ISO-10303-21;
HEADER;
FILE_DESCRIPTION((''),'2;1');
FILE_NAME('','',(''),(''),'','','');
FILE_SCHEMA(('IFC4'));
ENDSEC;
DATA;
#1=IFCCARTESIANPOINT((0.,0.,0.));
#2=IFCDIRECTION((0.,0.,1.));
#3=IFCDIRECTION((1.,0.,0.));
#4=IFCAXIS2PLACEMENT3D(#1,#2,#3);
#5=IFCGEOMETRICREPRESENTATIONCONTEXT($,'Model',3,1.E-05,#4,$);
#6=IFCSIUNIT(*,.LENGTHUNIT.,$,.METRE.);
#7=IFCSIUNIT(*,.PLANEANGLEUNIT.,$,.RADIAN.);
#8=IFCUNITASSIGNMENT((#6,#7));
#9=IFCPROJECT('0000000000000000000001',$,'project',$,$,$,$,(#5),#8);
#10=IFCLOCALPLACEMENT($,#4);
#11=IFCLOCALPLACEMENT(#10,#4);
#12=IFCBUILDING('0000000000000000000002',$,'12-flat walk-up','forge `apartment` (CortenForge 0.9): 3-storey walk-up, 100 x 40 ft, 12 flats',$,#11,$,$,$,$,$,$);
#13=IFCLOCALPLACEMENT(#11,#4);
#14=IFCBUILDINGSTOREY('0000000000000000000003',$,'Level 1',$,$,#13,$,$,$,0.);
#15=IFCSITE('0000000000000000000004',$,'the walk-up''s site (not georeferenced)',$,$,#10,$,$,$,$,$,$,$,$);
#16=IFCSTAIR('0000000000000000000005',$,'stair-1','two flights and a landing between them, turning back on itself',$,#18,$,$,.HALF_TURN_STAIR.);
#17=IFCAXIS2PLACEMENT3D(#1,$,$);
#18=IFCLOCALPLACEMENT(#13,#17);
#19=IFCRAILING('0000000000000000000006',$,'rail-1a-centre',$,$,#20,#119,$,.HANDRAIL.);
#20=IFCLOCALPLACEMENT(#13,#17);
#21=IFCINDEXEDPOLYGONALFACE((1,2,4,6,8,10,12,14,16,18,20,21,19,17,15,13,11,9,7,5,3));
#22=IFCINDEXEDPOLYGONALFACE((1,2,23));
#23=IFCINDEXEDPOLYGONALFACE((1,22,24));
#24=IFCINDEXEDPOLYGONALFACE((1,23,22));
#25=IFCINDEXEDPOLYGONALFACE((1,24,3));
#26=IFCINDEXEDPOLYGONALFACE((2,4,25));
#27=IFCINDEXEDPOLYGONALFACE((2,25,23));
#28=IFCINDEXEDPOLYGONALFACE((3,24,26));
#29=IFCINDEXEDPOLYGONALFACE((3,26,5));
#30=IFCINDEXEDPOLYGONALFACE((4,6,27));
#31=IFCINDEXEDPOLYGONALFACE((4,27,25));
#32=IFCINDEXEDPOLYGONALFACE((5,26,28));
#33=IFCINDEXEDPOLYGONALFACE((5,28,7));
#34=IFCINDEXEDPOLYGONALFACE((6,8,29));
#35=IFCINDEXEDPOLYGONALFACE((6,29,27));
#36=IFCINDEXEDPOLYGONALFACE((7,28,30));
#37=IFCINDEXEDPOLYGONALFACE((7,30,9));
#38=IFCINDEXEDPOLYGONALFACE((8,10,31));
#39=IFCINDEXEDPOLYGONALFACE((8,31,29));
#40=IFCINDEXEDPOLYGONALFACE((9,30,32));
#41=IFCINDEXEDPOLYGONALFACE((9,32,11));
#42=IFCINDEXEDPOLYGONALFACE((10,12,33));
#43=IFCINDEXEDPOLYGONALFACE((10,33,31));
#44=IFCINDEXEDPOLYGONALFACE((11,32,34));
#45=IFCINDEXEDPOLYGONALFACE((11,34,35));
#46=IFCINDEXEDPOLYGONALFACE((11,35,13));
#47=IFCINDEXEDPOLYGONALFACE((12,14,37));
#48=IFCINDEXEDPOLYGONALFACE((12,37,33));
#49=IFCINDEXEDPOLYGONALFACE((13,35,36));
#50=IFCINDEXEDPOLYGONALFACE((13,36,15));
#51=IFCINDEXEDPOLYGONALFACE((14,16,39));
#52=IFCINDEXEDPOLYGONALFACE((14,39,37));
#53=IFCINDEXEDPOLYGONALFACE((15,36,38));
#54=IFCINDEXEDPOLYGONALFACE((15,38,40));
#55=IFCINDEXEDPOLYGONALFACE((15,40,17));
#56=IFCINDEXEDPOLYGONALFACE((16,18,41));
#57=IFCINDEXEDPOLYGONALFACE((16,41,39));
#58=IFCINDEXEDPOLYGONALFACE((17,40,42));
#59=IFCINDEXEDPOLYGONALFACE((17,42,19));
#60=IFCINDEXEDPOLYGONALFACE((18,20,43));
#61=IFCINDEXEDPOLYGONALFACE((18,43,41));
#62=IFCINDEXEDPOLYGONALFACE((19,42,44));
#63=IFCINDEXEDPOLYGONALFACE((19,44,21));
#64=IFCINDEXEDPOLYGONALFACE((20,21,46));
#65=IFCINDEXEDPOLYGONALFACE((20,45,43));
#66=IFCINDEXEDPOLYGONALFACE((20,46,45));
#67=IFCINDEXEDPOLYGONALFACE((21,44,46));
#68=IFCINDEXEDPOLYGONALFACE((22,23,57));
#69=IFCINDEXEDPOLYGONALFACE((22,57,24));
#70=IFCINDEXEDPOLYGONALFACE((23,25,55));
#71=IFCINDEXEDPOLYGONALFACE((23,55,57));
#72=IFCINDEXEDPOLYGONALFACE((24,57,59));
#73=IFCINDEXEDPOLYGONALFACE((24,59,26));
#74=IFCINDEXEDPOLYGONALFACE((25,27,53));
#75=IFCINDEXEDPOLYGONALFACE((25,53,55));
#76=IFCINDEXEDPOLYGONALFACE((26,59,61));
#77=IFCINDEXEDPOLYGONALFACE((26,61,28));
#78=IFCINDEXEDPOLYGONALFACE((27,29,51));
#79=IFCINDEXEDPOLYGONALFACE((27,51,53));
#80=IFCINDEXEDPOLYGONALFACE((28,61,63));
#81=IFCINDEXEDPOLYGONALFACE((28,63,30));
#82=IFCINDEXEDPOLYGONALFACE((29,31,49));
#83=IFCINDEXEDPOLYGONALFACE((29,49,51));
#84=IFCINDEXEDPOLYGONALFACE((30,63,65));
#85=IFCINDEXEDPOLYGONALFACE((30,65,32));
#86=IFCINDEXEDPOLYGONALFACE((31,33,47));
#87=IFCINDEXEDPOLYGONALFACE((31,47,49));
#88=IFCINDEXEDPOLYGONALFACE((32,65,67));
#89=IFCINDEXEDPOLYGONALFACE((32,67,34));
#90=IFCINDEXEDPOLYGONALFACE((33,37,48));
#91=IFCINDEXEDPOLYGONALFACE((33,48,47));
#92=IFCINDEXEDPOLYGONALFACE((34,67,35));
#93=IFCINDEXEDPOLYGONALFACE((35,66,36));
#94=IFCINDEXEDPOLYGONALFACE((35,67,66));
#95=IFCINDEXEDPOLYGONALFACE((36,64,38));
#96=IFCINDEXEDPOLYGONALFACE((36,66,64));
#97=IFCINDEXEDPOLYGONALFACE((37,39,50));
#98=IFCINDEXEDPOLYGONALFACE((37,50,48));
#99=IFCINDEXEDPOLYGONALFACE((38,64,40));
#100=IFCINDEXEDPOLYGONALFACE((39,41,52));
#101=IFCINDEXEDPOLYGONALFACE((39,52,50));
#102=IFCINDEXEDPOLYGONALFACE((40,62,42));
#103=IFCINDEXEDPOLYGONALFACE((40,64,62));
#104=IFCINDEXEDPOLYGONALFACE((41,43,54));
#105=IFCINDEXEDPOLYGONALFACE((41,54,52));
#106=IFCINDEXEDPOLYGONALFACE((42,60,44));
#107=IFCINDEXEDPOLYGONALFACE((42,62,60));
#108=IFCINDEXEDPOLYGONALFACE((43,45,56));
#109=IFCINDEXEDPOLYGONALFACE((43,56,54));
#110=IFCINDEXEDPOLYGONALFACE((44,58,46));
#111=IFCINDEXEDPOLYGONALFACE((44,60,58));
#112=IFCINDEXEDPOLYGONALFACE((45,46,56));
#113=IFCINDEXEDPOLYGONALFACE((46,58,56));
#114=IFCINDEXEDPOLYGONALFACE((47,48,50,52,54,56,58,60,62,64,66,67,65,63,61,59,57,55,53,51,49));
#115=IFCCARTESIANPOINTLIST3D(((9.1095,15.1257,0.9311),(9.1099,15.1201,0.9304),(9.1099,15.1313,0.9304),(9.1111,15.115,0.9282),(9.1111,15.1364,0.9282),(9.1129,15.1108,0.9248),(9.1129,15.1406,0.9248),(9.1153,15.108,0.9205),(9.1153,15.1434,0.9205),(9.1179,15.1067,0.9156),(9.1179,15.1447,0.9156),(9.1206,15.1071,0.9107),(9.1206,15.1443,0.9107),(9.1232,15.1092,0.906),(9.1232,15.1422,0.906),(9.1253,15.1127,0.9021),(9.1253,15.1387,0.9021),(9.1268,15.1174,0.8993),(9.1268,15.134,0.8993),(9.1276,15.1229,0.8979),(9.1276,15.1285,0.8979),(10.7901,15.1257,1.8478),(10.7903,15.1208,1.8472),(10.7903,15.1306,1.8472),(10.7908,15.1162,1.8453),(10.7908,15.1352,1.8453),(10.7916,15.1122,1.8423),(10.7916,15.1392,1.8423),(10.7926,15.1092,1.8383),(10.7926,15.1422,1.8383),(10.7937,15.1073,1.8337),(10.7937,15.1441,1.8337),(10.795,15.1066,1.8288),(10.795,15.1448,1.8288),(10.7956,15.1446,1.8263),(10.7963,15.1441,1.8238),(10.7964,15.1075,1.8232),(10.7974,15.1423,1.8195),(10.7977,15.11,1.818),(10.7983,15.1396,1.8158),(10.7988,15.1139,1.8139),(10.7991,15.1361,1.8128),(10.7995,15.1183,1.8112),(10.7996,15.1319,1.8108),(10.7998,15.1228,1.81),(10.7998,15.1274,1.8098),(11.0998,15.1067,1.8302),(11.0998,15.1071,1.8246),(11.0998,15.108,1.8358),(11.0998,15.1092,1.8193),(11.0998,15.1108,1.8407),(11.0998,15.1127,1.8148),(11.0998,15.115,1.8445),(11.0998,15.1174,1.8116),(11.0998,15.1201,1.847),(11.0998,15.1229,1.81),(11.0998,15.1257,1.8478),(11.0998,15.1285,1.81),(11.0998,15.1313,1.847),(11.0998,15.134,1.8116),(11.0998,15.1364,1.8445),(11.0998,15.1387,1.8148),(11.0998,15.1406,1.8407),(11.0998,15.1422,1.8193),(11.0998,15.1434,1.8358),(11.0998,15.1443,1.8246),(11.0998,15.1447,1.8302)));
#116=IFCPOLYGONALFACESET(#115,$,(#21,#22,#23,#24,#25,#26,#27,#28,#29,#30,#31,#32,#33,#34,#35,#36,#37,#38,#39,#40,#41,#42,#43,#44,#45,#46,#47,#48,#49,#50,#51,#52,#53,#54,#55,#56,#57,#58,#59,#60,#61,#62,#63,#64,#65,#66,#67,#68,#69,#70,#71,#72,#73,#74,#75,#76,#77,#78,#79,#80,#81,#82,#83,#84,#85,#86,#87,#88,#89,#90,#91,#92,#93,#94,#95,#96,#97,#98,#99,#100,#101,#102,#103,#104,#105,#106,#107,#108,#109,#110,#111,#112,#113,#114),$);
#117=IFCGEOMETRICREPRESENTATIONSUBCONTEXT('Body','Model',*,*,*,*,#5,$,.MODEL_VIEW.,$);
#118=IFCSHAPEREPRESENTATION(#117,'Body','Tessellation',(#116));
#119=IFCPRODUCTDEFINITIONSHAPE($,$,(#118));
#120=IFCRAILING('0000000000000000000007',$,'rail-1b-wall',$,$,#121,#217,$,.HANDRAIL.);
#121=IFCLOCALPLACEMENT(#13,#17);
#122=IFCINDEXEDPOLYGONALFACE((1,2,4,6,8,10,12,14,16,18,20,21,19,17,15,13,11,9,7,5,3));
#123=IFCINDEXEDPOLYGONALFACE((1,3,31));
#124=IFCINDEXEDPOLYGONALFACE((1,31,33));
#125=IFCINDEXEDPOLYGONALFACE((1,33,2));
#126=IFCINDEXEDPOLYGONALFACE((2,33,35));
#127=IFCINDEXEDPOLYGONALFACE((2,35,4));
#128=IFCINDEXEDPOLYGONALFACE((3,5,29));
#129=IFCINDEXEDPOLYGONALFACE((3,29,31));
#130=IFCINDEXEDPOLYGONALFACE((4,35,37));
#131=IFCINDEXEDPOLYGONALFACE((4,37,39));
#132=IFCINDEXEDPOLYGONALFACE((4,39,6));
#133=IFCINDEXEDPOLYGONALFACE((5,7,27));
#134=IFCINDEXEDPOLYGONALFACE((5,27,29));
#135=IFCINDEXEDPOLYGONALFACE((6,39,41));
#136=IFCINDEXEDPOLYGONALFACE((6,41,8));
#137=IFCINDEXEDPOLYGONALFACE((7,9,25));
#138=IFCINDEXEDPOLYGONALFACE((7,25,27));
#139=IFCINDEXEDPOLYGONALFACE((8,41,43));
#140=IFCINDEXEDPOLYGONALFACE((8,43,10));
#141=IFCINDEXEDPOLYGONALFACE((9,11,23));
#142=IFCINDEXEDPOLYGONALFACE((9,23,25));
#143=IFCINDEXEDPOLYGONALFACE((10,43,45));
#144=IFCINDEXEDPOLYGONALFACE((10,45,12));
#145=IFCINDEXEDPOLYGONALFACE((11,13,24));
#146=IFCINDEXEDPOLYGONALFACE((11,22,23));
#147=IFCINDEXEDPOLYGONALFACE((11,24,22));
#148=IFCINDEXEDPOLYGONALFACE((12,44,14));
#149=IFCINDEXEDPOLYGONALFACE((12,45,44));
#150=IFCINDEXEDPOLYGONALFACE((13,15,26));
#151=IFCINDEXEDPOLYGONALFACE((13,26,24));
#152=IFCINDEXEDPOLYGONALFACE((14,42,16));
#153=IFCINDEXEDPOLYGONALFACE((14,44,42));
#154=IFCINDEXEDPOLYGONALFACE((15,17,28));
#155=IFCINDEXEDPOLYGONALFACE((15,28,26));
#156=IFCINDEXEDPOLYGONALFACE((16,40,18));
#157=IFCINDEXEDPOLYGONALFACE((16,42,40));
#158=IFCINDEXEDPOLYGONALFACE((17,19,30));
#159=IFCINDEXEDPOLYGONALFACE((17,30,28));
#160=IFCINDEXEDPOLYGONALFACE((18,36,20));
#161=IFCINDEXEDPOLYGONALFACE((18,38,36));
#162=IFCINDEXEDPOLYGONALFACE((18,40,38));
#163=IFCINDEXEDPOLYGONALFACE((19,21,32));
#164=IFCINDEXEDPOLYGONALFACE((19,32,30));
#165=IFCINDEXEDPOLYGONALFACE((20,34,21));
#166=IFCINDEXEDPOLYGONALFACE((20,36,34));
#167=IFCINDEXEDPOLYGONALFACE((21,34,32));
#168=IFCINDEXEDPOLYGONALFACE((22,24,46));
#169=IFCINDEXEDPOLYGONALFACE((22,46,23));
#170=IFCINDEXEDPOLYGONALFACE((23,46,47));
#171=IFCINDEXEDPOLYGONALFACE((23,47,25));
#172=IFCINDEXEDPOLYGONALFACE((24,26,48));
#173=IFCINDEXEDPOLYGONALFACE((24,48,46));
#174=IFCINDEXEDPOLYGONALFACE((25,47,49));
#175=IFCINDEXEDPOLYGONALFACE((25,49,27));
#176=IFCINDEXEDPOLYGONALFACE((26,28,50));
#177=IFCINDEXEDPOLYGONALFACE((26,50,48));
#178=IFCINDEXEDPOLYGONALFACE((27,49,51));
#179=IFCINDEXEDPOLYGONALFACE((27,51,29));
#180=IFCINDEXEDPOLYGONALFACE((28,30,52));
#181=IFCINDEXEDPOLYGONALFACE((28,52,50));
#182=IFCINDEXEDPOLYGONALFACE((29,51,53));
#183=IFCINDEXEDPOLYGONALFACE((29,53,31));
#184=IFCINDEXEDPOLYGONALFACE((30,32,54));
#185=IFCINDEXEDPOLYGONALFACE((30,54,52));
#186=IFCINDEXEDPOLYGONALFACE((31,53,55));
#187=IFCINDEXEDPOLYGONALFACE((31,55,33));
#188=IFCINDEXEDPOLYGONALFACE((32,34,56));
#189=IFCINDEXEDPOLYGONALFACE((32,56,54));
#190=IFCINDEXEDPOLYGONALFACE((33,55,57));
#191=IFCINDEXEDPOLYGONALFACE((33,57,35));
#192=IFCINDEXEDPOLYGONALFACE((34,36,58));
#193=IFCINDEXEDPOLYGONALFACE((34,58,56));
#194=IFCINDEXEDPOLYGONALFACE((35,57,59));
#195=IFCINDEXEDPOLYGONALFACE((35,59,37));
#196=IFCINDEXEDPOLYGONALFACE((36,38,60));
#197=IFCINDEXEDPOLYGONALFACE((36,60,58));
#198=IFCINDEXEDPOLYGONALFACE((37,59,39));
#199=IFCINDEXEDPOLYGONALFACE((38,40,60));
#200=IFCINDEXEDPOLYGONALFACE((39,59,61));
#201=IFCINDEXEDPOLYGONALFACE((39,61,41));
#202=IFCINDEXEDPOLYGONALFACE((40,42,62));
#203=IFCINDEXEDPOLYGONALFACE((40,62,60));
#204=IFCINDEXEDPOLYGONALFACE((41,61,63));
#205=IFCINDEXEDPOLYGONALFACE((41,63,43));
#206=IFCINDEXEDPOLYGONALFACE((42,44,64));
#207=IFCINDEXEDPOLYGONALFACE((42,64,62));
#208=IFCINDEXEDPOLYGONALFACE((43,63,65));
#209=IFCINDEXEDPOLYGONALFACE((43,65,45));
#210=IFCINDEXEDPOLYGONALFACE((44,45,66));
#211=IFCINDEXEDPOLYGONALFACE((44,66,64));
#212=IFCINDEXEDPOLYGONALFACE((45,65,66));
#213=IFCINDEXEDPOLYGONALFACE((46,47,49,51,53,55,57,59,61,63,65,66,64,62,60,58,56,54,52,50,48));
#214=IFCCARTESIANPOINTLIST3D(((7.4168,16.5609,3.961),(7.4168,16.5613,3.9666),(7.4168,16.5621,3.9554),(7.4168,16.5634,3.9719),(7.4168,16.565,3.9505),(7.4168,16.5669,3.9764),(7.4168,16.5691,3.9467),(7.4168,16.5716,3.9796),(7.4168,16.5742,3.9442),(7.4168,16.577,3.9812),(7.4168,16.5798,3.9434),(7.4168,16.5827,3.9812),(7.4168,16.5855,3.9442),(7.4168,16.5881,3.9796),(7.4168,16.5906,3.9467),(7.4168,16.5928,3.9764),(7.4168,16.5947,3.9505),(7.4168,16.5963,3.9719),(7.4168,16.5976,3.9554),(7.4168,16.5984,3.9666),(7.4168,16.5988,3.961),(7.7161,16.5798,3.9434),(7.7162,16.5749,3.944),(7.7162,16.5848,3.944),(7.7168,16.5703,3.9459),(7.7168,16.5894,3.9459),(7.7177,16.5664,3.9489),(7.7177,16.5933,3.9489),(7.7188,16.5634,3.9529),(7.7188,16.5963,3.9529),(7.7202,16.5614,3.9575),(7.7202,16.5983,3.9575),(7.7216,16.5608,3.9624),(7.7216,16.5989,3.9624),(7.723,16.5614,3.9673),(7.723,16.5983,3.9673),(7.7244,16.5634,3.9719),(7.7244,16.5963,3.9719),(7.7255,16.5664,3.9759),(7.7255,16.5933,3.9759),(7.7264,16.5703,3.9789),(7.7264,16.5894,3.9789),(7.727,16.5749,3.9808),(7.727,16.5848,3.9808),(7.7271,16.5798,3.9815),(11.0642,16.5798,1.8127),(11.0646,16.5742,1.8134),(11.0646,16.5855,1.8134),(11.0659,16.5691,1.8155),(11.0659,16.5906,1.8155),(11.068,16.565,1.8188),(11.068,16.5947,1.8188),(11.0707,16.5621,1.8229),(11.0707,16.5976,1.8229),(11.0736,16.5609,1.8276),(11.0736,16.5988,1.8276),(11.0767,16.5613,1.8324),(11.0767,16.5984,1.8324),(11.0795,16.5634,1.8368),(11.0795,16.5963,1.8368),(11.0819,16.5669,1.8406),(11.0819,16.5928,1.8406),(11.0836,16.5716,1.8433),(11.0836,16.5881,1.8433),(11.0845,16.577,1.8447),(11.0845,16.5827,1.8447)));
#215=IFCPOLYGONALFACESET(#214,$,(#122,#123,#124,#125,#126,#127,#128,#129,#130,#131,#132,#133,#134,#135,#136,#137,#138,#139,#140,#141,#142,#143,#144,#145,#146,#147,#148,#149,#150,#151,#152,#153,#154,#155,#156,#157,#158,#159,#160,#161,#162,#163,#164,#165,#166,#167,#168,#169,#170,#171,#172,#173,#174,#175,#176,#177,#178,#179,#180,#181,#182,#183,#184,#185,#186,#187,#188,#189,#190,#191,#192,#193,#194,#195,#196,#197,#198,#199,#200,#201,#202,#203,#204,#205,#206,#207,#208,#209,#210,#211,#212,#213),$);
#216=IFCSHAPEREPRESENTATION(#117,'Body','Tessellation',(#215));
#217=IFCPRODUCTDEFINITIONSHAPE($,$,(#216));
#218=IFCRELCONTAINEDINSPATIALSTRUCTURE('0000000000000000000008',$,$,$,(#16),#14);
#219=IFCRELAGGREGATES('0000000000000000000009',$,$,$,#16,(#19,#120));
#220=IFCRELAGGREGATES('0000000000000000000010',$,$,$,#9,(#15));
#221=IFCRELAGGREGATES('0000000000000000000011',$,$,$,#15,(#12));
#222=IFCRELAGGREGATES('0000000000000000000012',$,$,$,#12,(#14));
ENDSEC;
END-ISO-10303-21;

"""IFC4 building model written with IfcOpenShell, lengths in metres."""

from ifc_helpers import new_model, entity, si_unit, frame, origin_with_axes, place, context, subcontext, project, spatial, element, aggregate, save


model = new_model("IFC4")

# Units and contexts
model_context = context("Model", 3, precision=1e-05, world=origin_with_axes())
body_context = subcontext(model_context, "Body", "Model", "MODEL_VIEW")
ifc_project = project(units=[si_unit("LENGTHUNIT", "METRE"), si_unit("PLANEANGLEUNIT", "RADIAN")], contexts=[model_context])

# Site, building, storey
site_placement = place(None, origin_with_axes())
site = spatial("IfcSite", under=ifc_project, at=site_placement, Name="the walk-up's site (not georeferenced)")
building_placement = place(site_placement, origin_with_axes())
building = spatial("IfcBuilding", under=site, at=building_placement, Name="12-flat walk-up", Description="forge `apartment` (CortenForge 0.9): 3-storey walk-up, 100 x 40 ft, 12 flats")
storey_placement = place(building_placement, origin_with_axes())
storey = spatial("IfcBuildingStorey", under=building, at=storey_placement, Name="Level 1", Elevation=0.0)

# Stair, railings
stair_placement = place(storey_placement, origin_with_axes())
stair = element("IfcStair", 1, at=stair_placement, inside=storey, Name="stair-1", Description="two flights and a landing between them, turning back on itself", PredefinedType="HALF_TURN_STAIR")
railing_1_placement = place(stair_placement, frame((9.1186, 15.1257, 0.9144), z_axis=(0.0, 0.0, 1.0), x_axis=(1.0, 0.0, 0.0)))
railing_1 = element("IfcRailing", 2, at=railing_1_placement, Name="rail-1a-centre", PredefinedType="HANDRAIL", context=body_context, shape_type="AdvancedSweptSolid", body=[
    entity("IfcSweptDiskSolid", entity("IfcPolyline", [entity("IfcCartesianPoint", [0.0, 0.0, 0.0]), entity("IfcCartesianPoint", [1.6764, 0.0, 0.9144]), entity("IfcCartesianPoint", [1.9812, 0.0, 0.9144])]), 0.0191),
])
railing_2_placement = place(stair_placement, frame((11.0744, 16.5799, 1.8288), z_axis=(0.0, 0.0, 1.0), x_axis=(1.0, 0.0, 0.0)))
railing_2 = element("IfcRailing", 3, at=railing_2_placement, Name="rail-1b-wall", PredefinedType="HANDRAIL", context=body_context, shape_type="AdvancedSweptSolid", body=[
    entity("IfcSweptDiskSolid", entity("IfcPolyline", [entity("IfcCartesianPoint", [0.0, 0.0, 0.0]), entity("IfcCartesianPoint", [-3.3528, 0.0, 2.1336]), entity("IfcCartesianPoint", [-3.6576, 0.0, 2.1336])]), 0.0191),
])
aggregate(stair, [railing_1, railing_2])

save(model, "model.ifc")
